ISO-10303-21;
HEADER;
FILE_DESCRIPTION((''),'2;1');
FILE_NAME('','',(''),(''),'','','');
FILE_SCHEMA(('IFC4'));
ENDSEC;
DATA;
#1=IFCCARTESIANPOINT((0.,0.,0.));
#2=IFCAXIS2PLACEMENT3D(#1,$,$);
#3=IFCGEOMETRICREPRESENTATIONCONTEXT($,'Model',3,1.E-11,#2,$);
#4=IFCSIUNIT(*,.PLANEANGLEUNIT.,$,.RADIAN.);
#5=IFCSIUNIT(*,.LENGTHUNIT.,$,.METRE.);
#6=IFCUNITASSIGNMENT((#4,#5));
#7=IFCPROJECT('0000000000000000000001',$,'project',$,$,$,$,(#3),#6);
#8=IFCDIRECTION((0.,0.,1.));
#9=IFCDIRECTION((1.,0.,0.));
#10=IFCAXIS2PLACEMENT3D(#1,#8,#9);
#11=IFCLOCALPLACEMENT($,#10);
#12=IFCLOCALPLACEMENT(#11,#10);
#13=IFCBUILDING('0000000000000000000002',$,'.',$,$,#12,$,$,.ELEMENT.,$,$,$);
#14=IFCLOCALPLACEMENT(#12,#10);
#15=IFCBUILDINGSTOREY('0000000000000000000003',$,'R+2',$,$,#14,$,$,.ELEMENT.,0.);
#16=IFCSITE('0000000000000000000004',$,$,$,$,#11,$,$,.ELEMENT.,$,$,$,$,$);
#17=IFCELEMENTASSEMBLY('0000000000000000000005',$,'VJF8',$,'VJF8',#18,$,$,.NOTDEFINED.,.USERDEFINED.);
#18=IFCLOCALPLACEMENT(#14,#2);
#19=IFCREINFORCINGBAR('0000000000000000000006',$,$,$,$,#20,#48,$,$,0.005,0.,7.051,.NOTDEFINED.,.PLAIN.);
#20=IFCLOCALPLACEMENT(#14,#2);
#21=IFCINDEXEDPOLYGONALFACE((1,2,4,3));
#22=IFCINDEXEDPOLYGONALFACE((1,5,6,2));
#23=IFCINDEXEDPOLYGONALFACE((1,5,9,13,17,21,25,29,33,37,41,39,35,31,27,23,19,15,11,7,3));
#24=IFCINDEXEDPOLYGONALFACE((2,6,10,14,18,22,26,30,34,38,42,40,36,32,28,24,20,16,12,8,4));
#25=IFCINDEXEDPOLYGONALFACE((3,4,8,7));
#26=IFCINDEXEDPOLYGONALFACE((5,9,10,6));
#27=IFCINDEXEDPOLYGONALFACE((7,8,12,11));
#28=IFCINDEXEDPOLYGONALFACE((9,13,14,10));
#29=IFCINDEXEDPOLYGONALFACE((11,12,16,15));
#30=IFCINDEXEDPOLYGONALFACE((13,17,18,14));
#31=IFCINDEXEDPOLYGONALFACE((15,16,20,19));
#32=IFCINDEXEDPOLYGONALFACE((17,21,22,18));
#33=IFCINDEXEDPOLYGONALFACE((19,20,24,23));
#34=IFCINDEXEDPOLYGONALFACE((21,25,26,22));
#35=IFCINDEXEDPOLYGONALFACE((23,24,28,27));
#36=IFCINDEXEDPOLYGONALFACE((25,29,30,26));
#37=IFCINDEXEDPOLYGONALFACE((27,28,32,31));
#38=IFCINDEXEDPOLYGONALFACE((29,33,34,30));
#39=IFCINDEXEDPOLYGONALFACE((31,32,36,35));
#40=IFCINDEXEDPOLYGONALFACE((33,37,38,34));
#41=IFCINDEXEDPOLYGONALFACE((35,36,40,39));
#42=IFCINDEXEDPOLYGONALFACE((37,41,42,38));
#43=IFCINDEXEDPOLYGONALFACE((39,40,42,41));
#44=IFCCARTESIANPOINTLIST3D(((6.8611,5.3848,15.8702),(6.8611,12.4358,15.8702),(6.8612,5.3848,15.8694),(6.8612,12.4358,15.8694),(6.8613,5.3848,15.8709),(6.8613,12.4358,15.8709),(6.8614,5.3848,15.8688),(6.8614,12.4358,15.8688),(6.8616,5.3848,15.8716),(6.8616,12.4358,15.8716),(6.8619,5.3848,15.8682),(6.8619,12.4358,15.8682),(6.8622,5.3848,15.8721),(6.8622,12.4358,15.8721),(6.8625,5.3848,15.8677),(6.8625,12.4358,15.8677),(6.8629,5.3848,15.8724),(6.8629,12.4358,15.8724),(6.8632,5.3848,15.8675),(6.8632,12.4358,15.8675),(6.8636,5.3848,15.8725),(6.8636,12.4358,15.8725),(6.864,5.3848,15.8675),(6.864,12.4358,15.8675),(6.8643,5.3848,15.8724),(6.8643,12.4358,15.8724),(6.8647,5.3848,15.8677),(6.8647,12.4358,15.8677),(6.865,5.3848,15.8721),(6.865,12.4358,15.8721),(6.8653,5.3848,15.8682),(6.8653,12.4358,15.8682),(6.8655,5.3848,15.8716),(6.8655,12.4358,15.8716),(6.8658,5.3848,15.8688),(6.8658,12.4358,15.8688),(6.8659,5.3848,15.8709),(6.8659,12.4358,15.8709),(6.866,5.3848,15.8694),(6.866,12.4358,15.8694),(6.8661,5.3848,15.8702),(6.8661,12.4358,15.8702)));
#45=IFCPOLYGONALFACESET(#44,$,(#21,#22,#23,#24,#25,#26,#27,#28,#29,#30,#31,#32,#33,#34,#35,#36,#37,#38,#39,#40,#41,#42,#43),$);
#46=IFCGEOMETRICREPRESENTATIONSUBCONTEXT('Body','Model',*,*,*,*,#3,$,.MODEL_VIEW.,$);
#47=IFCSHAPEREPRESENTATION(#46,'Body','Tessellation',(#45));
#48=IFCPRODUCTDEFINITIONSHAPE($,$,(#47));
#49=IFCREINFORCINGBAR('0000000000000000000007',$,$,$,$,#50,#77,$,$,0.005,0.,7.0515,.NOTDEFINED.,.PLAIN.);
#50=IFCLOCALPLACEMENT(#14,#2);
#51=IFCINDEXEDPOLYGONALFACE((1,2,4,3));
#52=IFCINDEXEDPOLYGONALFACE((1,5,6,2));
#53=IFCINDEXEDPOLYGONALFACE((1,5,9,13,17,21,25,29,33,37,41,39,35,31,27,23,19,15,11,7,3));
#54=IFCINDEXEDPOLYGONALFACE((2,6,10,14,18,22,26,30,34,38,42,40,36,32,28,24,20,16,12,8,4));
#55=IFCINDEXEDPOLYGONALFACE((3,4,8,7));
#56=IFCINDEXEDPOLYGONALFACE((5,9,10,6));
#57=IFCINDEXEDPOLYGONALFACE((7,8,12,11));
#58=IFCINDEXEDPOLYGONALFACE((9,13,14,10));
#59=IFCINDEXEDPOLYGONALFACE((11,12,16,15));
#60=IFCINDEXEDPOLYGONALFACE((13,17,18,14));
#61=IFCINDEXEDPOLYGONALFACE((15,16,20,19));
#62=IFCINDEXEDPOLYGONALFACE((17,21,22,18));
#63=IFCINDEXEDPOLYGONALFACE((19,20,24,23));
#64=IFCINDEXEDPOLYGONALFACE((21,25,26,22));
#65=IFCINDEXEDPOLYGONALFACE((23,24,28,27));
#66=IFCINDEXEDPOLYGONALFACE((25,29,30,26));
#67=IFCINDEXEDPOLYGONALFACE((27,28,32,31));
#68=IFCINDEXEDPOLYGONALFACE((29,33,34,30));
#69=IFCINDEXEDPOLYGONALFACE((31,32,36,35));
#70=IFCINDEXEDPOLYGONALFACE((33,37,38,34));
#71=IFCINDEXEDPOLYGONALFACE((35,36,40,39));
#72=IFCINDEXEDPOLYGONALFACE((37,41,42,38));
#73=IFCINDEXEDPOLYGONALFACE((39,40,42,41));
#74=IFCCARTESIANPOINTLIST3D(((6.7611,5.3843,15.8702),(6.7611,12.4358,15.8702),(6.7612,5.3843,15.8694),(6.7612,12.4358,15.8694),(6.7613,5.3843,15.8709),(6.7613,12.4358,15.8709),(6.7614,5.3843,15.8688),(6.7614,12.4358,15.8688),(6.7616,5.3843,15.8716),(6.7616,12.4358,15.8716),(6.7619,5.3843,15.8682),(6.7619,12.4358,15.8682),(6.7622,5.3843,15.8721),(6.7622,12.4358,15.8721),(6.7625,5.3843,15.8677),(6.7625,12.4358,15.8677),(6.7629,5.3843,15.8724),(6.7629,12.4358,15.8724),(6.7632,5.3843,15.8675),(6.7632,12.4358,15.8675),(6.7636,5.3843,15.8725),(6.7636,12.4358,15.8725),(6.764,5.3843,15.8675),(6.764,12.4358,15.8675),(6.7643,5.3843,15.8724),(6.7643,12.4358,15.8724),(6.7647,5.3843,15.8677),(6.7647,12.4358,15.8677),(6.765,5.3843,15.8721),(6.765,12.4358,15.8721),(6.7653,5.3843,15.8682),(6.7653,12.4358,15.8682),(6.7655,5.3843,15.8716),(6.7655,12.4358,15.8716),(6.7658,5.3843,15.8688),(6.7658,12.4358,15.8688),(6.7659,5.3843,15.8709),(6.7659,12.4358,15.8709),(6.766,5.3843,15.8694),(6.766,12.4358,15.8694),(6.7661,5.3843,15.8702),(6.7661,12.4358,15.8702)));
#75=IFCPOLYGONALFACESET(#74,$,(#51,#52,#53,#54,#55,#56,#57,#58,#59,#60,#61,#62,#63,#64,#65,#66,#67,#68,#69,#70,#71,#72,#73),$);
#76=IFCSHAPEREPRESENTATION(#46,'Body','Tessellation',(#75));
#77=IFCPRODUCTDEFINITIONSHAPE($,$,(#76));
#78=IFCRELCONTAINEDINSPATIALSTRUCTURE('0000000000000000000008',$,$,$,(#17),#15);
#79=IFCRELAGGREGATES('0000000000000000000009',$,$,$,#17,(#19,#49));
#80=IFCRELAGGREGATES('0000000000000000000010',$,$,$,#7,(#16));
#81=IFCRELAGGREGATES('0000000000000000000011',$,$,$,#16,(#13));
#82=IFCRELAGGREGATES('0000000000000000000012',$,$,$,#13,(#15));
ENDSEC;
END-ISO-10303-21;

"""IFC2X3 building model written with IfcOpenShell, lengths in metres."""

from ifc_helpers import new_model, entity, si_unit, origin, origin_with_axes, place, context, subcontext, project, spatial, shape, element, aggregate, save


model = new_model("IFC2X3")

# Units and contexts
model_context = context("Model", 3, precision=1e-11, world=origin())
body_context = subcontext(model_context, "Body", "Model", "MODEL_VIEW")
ifc_project = project(units=[si_unit("PLANEANGLEUNIT", "RADIAN"), si_unit("LENGTHUNIT", "METRE")], contexts=[model_context])

# Site, building, storey
site_placement = place(None, origin_with_axes())
site = spatial("IfcSite", under=ifc_project, at=site_placement, CompositionType="ELEMENT")
building_placement = place(site_placement, origin_with_axes())
building = spatial("IfcBuilding", under=site, at=building_placement, Name=".", CompositionType="ELEMENT")
storey_placement = place(building_placement, origin_with_axes())
storey = spatial("IfcBuildingStorey", under=building, at=storey_placement, Name="R+2", CompositionType="ELEMENT", Elevation=0.0)

# Element assembly, reinforcing bars
assembly_1_placement = place(storey_placement, origin_with_axes())
assembly_1 = element("IfcElementAssembly", 1, at=assembly_1_placement, inside=storey, Name="VJF8", ObjectType="VJF8", AssemblyPlace="NOTDEFINED", PredefinedType="USERDEFINED")
reinforcing_bar_1_placement = place(assembly_1_placement, origin_with_axes())
reinforcing_bar_1 = element("IfcReinforcingBar", 2, at=reinforcing_bar_1_placement, BarLength=7.051, BarRole="NOTDEFINED", BarSurface="PLAIN", CrossSectionArea=0.0, NominalDiameter=0.005, shapes=[
    shape(body_context, "Body", "AdvancedSweptSolid", [entity("IfcSweptDiskSolid", entity("IfcPolyline", [entity("IfcCartesianPoint", [6.8636, 5.3848, 15.87]), entity("IfcCartesianPoint", [6.8636, 12.4358, 15.87])]), 0.0025, None, 0.0, 7.051)]),
    shape(body_context, "Body", "AdvancedSweptSolid", [entity("IfcSweptDiskSolid", entity("IfcPolyline", [entity("IfcCartesianPoint", [6.8636, 5.3848, 15.87]), entity("IfcCartesianPoint", [6.8636, 12.4358, 15.87])]), 0.0025, None, 0.0, 7.051)]),
])
reinforcing_bar_2_placement = place(assembly_1_placement, origin_with_axes())
reinforcing_bar_2 = element("IfcReinforcingBar", 3, at=reinforcing_bar_2_placement, BarLength=7.0515, BarRole="NOTDEFINED", BarSurface="PLAIN", CrossSectionArea=0.0, NominalDiameter=0.005, shapes=[
    shape(body_context, "Body", "AdvancedSweptSolid", [entity("IfcSweptDiskSolid", entity("IfcPolyline", [entity("IfcCartesianPoint", [6.7636, 5.3843, 15.87]), entity("IfcCartesianPoint", [6.7636, 12.4358, 15.87])]), 0.0025, None, 0.0, 7.0515)]),
    shape(body_context, "Body", "AdvancedSweptSolid", [entity("IfcSweptDiskSolid", entity("IfcPolyline", [entity("IfcCartesianPoint", [6.7636, 5.3843, 15.87]), entity("IfcCartesianPoint", [6.7636, 12.4358, 15.87])]), 0.0025, None, 0.0, 7.0515)]),
])
aggregate(assembly_1, [reinforcing_bar_1, reinforcing_bar_2])

save(model, "model.ifc")
